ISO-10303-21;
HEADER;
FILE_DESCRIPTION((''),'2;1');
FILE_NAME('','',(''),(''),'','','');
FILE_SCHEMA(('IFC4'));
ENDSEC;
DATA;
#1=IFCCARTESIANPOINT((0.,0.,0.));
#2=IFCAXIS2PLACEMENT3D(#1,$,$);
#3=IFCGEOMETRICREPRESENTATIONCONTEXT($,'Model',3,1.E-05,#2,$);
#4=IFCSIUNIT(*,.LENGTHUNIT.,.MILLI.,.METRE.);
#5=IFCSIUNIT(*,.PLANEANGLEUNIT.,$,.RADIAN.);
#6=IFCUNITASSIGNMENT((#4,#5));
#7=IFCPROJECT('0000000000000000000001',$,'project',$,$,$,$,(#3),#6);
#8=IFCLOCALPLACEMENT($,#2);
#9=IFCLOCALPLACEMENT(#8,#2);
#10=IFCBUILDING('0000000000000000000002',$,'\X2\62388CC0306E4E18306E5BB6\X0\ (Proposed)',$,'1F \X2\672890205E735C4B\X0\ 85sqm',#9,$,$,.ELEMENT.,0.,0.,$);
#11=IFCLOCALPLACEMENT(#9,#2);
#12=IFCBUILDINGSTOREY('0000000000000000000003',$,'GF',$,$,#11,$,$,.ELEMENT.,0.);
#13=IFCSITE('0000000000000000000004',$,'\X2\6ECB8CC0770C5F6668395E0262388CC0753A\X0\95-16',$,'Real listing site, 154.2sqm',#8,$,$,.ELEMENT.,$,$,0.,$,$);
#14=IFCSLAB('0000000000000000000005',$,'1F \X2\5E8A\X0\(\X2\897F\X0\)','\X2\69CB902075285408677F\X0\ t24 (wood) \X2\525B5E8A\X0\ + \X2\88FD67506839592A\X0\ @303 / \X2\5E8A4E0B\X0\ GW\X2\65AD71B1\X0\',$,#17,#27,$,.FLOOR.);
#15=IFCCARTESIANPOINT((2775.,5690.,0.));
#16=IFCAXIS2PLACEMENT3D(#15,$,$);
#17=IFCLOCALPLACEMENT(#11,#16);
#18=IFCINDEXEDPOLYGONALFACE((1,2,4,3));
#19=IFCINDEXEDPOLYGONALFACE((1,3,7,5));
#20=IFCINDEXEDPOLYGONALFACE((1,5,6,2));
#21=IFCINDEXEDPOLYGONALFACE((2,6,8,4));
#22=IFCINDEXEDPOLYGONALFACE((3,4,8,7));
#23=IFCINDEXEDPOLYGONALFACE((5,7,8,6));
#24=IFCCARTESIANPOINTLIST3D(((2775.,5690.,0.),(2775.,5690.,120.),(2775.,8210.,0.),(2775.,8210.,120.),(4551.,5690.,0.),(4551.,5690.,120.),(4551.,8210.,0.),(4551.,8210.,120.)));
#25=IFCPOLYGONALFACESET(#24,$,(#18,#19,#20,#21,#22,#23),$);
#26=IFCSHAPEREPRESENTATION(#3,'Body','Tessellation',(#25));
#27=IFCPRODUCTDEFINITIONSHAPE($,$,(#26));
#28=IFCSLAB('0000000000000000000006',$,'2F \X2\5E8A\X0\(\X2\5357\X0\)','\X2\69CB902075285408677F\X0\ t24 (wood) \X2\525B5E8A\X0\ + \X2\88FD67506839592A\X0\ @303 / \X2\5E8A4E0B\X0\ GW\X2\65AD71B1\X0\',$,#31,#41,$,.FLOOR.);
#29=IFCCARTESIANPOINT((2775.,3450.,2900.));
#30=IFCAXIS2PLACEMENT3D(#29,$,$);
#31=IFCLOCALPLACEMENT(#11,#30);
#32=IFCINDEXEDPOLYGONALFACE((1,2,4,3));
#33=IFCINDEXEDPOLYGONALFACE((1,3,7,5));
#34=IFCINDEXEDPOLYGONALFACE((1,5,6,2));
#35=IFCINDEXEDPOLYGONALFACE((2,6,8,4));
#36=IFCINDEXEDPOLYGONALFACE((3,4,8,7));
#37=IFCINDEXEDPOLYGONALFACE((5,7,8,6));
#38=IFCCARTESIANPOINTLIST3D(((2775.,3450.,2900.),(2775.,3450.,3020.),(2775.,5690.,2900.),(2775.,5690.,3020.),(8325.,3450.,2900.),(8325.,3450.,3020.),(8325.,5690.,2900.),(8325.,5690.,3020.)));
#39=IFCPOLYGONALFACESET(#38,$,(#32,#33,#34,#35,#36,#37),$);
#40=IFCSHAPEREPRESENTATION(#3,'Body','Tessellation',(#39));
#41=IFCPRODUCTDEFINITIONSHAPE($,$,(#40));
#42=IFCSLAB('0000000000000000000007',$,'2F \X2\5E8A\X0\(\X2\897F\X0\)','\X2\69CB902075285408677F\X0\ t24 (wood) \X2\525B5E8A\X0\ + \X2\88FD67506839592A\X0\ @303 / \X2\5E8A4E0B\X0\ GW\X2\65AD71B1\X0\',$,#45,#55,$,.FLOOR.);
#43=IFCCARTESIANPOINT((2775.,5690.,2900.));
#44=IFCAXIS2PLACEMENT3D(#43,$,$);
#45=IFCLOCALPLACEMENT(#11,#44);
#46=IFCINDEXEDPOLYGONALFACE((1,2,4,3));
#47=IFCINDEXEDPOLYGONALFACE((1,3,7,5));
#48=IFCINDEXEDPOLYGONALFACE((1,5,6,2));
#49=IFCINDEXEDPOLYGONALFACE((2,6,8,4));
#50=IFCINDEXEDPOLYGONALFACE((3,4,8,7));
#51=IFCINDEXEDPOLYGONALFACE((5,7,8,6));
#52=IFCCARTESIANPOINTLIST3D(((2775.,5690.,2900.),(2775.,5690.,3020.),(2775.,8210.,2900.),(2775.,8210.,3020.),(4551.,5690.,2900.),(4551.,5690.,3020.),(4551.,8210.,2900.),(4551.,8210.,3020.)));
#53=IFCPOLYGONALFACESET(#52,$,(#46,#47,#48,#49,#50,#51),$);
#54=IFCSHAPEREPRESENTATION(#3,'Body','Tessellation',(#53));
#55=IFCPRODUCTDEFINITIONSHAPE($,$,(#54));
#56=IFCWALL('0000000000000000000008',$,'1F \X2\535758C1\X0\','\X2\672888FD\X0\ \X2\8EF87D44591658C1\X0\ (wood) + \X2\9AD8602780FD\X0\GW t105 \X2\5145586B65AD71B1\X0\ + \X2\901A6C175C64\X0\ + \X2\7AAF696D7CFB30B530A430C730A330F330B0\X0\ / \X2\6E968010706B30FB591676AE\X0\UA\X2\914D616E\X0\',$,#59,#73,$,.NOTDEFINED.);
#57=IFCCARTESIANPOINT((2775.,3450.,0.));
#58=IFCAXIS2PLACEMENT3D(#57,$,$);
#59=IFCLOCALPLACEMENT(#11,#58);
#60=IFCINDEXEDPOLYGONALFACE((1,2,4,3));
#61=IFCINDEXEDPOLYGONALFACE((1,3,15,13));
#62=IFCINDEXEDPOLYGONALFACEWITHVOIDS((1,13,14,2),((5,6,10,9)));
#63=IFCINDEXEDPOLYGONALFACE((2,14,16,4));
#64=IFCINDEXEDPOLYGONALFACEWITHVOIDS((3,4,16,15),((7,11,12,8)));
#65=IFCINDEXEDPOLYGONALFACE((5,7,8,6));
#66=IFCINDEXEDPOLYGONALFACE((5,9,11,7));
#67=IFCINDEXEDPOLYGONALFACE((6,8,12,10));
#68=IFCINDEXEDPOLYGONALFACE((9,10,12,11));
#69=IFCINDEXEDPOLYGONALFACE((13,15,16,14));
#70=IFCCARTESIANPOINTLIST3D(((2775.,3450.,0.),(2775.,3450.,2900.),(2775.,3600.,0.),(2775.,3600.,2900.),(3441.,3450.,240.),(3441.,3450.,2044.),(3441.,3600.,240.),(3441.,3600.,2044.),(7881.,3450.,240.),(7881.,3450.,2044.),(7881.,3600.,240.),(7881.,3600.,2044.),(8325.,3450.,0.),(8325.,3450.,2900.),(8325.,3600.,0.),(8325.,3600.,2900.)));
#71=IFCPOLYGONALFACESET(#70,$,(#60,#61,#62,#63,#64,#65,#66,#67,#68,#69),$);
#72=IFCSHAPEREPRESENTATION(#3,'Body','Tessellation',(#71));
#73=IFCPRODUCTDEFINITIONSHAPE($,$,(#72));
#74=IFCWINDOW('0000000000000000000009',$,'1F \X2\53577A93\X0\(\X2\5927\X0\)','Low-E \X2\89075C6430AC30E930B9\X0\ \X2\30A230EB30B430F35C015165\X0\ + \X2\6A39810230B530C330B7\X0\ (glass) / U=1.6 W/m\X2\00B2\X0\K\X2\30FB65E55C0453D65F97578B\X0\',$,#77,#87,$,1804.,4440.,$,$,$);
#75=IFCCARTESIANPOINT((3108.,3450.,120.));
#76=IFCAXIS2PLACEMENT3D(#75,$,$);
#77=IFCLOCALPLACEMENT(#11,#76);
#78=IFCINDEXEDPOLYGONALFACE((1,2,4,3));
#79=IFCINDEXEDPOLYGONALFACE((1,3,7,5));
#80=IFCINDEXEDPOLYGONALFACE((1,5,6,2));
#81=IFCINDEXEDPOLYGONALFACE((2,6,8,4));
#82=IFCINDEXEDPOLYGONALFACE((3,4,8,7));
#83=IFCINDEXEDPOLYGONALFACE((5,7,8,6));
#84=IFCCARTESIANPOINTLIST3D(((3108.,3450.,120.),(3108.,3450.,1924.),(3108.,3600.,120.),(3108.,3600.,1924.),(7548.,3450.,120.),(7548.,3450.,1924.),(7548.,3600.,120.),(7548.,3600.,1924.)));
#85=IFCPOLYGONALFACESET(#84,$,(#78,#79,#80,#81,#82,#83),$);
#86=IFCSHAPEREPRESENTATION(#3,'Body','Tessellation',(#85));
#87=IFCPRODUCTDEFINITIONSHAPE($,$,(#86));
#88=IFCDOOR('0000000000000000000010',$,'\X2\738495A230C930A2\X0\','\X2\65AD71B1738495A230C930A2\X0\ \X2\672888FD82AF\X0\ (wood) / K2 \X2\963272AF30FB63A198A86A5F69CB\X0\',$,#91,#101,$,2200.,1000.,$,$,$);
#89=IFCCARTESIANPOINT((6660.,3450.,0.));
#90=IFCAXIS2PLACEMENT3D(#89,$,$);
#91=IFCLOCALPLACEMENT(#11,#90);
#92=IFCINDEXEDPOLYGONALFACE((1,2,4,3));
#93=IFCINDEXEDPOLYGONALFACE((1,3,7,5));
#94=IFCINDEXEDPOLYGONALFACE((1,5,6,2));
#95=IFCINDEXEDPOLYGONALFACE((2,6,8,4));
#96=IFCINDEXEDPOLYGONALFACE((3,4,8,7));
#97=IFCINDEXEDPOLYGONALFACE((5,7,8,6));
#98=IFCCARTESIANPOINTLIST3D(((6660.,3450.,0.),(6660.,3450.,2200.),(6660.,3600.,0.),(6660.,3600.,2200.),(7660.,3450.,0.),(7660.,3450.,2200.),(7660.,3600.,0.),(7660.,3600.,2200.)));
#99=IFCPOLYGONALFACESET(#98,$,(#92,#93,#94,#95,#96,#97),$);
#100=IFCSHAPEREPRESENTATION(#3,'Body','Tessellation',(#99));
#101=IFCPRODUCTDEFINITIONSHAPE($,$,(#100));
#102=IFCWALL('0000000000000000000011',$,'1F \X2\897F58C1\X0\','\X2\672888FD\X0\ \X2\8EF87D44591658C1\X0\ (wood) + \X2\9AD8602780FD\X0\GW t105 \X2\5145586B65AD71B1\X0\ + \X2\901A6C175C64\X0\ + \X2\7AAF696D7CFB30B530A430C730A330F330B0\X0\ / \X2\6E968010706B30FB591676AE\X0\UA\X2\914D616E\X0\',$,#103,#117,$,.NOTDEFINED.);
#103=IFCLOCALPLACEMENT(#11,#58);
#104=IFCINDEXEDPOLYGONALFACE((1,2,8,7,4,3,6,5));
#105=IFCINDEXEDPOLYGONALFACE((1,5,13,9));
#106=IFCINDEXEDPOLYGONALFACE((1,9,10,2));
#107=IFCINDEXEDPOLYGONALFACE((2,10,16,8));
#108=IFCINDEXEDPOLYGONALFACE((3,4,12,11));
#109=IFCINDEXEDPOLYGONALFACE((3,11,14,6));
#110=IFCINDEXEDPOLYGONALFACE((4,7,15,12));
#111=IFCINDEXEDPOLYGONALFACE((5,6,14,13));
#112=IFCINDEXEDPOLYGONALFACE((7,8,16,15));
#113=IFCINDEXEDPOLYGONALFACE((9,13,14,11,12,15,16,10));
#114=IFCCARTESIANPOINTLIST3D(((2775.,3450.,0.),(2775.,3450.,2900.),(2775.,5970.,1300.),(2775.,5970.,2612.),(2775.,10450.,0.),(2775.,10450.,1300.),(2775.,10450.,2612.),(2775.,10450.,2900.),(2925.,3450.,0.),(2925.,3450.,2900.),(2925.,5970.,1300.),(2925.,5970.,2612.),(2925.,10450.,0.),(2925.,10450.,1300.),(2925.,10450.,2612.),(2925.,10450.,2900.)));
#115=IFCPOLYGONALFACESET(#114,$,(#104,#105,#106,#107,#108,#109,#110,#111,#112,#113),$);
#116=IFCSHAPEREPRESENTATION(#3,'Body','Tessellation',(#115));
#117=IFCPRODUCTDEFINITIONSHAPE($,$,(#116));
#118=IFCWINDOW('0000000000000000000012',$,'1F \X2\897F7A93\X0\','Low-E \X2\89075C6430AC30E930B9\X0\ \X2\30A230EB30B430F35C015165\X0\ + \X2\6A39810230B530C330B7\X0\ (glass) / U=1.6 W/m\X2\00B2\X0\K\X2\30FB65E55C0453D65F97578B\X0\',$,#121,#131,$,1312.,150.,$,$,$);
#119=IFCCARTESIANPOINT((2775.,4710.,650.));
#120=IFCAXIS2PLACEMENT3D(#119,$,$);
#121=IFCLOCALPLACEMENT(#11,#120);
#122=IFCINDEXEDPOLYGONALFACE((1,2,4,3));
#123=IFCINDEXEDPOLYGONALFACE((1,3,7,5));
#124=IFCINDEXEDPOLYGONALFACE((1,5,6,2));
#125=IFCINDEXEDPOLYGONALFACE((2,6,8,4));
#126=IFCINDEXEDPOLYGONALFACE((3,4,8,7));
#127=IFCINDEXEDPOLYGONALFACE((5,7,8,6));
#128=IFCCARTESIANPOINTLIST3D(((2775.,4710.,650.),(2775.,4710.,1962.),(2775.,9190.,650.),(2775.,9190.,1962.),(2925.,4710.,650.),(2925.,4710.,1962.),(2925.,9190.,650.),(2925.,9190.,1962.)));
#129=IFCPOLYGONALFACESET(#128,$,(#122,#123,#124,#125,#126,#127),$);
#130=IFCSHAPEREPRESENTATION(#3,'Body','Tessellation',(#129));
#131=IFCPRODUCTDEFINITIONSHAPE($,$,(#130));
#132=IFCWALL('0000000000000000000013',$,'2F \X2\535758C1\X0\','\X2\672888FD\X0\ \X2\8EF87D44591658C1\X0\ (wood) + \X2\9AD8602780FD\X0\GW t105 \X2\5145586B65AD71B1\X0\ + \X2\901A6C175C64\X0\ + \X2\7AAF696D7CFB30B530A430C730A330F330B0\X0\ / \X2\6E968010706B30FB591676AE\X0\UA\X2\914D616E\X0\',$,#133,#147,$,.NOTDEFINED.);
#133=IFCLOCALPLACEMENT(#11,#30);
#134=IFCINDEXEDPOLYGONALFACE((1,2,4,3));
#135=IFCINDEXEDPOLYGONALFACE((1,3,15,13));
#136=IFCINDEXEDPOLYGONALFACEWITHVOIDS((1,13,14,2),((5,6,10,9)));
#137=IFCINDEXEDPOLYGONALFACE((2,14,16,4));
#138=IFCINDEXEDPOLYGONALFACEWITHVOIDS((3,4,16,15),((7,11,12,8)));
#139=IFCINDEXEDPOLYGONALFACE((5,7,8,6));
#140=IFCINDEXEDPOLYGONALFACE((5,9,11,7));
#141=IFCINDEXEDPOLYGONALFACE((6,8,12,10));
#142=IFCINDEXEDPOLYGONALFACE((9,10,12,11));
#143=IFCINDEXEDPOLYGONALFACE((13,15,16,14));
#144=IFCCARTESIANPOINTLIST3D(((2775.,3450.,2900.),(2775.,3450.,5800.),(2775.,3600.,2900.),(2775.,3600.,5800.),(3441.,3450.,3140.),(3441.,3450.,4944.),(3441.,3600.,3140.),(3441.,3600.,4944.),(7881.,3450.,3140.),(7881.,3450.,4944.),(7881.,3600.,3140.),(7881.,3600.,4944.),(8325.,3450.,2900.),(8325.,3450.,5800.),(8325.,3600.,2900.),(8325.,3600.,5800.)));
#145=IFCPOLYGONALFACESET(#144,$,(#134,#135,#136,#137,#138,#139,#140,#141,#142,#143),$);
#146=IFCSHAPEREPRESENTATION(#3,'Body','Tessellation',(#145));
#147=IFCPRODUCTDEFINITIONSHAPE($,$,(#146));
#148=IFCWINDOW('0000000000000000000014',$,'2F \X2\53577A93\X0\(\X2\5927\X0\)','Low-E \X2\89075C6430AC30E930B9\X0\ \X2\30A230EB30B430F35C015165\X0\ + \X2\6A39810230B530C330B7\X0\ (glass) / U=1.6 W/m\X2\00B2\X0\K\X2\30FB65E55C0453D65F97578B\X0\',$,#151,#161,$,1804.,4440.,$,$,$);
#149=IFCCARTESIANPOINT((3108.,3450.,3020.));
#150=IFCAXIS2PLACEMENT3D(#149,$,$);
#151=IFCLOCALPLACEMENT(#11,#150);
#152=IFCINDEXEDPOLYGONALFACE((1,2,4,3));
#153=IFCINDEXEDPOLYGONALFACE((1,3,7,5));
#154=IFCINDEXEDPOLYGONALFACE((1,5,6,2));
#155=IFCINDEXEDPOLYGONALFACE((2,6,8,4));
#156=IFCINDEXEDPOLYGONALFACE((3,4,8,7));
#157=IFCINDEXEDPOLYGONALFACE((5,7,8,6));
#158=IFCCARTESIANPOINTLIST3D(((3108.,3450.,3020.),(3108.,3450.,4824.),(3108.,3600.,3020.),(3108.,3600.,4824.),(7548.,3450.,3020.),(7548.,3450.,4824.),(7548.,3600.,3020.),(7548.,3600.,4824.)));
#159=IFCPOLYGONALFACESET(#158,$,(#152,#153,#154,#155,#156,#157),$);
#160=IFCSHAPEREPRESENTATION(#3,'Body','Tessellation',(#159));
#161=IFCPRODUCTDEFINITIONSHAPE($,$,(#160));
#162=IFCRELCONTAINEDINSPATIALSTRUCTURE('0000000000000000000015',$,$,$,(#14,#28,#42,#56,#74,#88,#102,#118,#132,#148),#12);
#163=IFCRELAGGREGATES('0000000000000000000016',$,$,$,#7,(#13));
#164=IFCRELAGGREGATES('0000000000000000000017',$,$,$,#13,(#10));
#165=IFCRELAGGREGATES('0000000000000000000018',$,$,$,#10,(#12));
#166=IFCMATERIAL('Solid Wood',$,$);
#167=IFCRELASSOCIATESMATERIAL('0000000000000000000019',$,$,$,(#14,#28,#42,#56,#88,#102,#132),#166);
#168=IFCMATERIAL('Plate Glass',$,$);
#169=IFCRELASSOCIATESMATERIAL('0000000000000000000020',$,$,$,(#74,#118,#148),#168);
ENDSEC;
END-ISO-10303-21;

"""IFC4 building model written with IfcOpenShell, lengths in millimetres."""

from ifc_helpers import new_model, si_unit, frame, frame_2d, origin, place, context, project, spatial, rectangle, extrude, material, element, fill, save


model = new_model("IFC4")

# Units and contexts
model_context = context("Model", 3, precision=1e-05, world=origin())
ifc_project = project(units=[si_unit("LENGTHUNIT", "METRE", prefix="MILLI"), si_unit("PLANEANGLEUNIT", "RADIAN")], contexts=[model_context])

# Site, building, storey
site_placement = place(None, origin())
site = spatial("IfcSite", under=ifc_project, at=site_placement, Name="滋賀県彦根市戸賀町95-16", ObjectType="Real listing site, 154.2sqm", CompositionType="ELEMENT", RefElevation=0.0)
building_placement = place(site_placement, origin())
building = spatial("IfcBuilding", under=site, at=building_placement, Name="戸賀の丘の家 (Proposed)", ObjectType="1F 木造平屋 85sqm", CompositionType="ELEMENT", ElevationOfRefHeight=0.0, ElevationOfTerrain=0.0)
storey_placement = place(building_placement, origin())
storey = spatial("IfcBuildingStorey", under=building, at=storey_placement, Name="GF", CompositionType="ELEMENT", Elevation=0.0)

# Slabs
ifc_material_1 = material(Name="Solid Wood")
slab_1_placement = place(storey_placement, frame((2775.0, 5690.0, 0.0)))
element("IfcSlab", 1, at=slab_1_placement, inside=storey, material=ifc_material_1, Name="1F 床(西)", Description="構造用合板 t24 (wood) 剛床 + 製材根太 @303 / 床下 GW断熱", PredefinedType="FLOOR", context=model_context, shape_type="SweptSolid", body=[
    extrude(rectangle(XDim=1776.0, YDim=2520.0, at=frame_2d((888.0, 1260.0))), frame((2775.0, 5690.0, 0.0)), (0.0, 0.0, 1.0), 120.0),
])
slab_2_placement = place(storey_placement, frame((2775.0, 3450.0, 2900.0)))
element("IfcSlab", 2, at=slab_2_placement, inside=storey, material=ifc_material_1, Name="2F 床(南)", Description="構造用合板 t24 (wood) 剛床 + 製材根太 @303 / 床下 GW断熱", PredefinedType="FLOOR", context=model_context, shape_type="SweptSolid", body=[
    extrude(rectangle(XDim=5550.0, YDim=2240.0, at=frame_2d((2775.0, 1120.0))), frame((2775.0, 3450.0, 2900.0)), (0.0, 0.0, 1.0), 120.0),
])
slab_3_placement = place(storey_placement, frame((2775.0, 5690.0, 2900.0)))
element("IfcSlab", 3, at=slab_3_placement, inside=storey, material=ifc_material_1, Name="2F 床(西)", Description="構造用合板 t24 (wood) 剛床 + 製材根太 @303 / 床下 GW断熱", PredefinedType="FLOOR", context=model_context, shape_type="SweptSolid", body=[
    extrude(rectangle(XDim=1776.0, YDim=2520.0, at=frame_2d((888.0, 1260.0))), frame((2775.0, 5690.0, 2900.0)), (0.0, 0.0, 1.0), 120.0),
])

# Wall, openings, window, door
wall_1_placement = place(storey_placement, frame((2775.0, 3450.0, 0.0)))
wall_1 = element("IfcWall", 4, at=wall_1_placement, inside=storey, material=ifc_material_1, Name="1F 南壁", Description="木製 軸組外壁 (wood) + 高性能GW t105 充填断熱 + 通気層 + 窯業系サイディング / 準耐火・外皮UA配慮", PredefinedType="NOTDEFINED", context=model_context, shape_type="SweptSolid", body=[
    extrude(rectangle(XDim=5550.0, YDim=150.0, at=frame_2d((2775.0, 75.0))), frame((2775.0, 3450.0, 0.0)), (0.0, 0.0, 1.0), 2900.0),
])
opening_1_placement = place(storey_placement, frame((3108.0, 3450.0, 120.0)))
opening_1 = element("IfcOpeningElement", 5, at=opening_1_placement, cuts=wall_1, PredefinedType="NOTDEFINED", context=model_context, shape_type="SweptSolid", body=[
    extrude(rectangle(XDim=4440.0, YDim=150.0, at=frame_2d((2220.0, 75.0))), frame((3108.0, 3450.0, 120.0)), (0.0, 0.0, 1.0), 1804.0),
])
opening_2_placement = place(storey_placement, frame((6660.0, 3450.0, 0.0)))
opening_2 = element("IfcOpeningElement", 6, at=opening_2_placement, cuts=wall_1, PredefinedType="NOTDEFINED", context=model_context, shape_type="SweptSolid", body=[
    extrude(rectangle(XDim=1000.0, YDim=150.0, at=frame_2d((500.0, 75.0))), frame((6660.0, 3450.0, 0.0)), (0.0, 0.0, 1.0), 2200.0),
])
ifc_material_2 = material(Name="Plate Glass")
window_1_placement = place(storey_placement, frame((3108.0, 3450.0, 120.0)))
window_1 = element("IfcWindow", 7, at=window_1_placement, inside=storey, material=ifc_material_2, Name="1F 南窓(大)", Description="Low-E 複層ガラス アルゴン封入 + 樹脂サッシ (glass) / U=1.6 W/m²K・日射取得型", OverallHeight=1804.0, OverallWidth=4440.0, context=model_context, shape_type="SweptSolid", body=[
    extrude(rectangle(XDim=4440.0, YDim=150.0, at=frame_2d((2220.0, 75.0))), frame((3108.0, 3450.0, 120.0)), (0.0, 0.0, 1.0), 1804.0),
])
fill(opening_1, window_1)
door_placement = place(storey_placement, frame((6660.0, 3450.0, 0.0)))
door = element("IfcDoor", 8, at=door_placement, inside=storey, material=ifc_material_1, Name="玄関ドア", Description="断熱玄関ドア 木製芯 (wood) / K2 防犯・採風機構", OverallHeight=2200.0, OverallWidth=1000.0, context=model_context, shape_type="SweptSolid", body=[
    extrude(rectangle(XDim=1000.0, YDim=150.0, at=frame_2d((500.0, 75.0))), frame((6660.0, 3450.0, 0.0)), (0.0, 0.0, 1.0), 2200.0),
])
fill(opening_2, door)

# Walls, openings, windows
wall_2_placement = place(storey_placement, frame((2775.0, 3450.0, 0.0)))
wall_2 = element("IfcWall", 9, at=wall_2_placement, inside=storey, material=ifc_material_1, Name="1F 西壁", Description="木製 軸組外壁 (wood) + 高性能GW t105 充填断熱 + 通気層 + 窯業系サイディング / 準耐火・外皮UA配慮", PredefinedType="NOTDEFINED", context=model_context, shape_type="SweptSolid", body=[
    extrude(rectangle(XDim=150.0, YDim=7000.0, at=frame_2d((75.0, 3500.0))), frame((2775.0, 3450.0, 0.0)), (0.0, 0.0, 1.0), 2900.0),
])
opening_3_placement = place(storey_placement, frame((2775.0, 4710.0, 650.0)))
opening_3 = element("IfcOpeningElement", 10, at=opening_3_placement, cuts=wall_2, PredefinedType="NOTDEFINED", context=model_context, shape_type="SweptSolid", body=[
    extrude(rectangle(XDim=150.0, YDim=4480.0, at=frame_2d((75.0, 2240.0))), frame((2775.0, 4710.0, 650.0)), (0.0, 0.0, 1.0), 1312.0),
])
window_2_placement = place(storey_placement, frame((2775.0, 4710.0, 650.0)))
window_2 = element("IfcWindow", 11, at=window_2_placement, inside=storey, material=ifc_material_2, Name="1F 西窓", Description="Low-E 複層ガラス アルゴン封入 + 樹脂サッシ (glass) / U=1.6 W/m²K・日射取得型", OverallHeight=1312.0, OverallWidth=150.0, context=model_context, shape_type="SweptSolid", body=[
    extrude(rectangle(XDim=150.0, YDim=4480.0, at=frame_2d((75.0, 2240.0))), frame((2775.0, 4710.0, 650.0)), (0.0, 0.0, 1.0), 1312.0),
])
fill(opening_3, window_2)
wall_3_placement = place(storey_placement, frame((2775.0, 3450.0, 2900.0)))
wall_3 = element("IfcWall", 12, at=wall_3_placement, inside=storey, material=ifc_material_1, Name="2F 南壁", Description="木製 軸組外壁 (wood) + 高性能GW t105 充填断熱 + 通気層 + 窯業系サイディング / 準耐火・外皮UA配慮", PredefinedType="NOTDEFINED", context=model_context, shape_type="SweptSolid", body=[
    extrude(rectangle(XDim=5550.0, YDim=150.0, at=frame_2d((2775.0, 75.0))), frame((2775.0, 3450.0, 2900.0)), (0.0, 0.0, 1.0), 2900.0),
])
opening_4_placement = place(storey_placement, frame((3108.0, 3450.0, 3020.0)))
opening_4 = element("IfcOpeningElement", 13, at=opening_4_placement, cuts=wall_3, PredefinedType="NOTDEFINED", context=model_context, shape_type="SweptSolid", body=[
    extrude(rectangle(XDim=4440.0, YDim=150.0, at=frame_2d((2220.0, 75.0))), frame((3108.0, 3450.0, 3020.0)), (0.0, 0.0, 1.0), 1804.0),
])
window_3_placement = place(storey_placement, frame((3108.0, 3450.0, 3020.0)))
window_3 = element("IfcWindow", 14, at=window_3_placement, inside=storey, material=ifc_material_2, Name="2F 南窓(大)", Description="Low-E 複層ガラス アルゴン封入 + 樹脂サッシ (glass) / U=1.6 W/m²K・日射取得型", OverallHeight=1804.0, OverallWidth=4440.0, context=model_context, shape_type="SweptSolid", body=[
    extrude(rectangle(XDim=4440.0, YDim=150.0, at=frame_2d((2220.0, 75.0))), frame((3108.0, 3450.0, 3020.0)), (0.0, 0.0, 1.0), 1804.0),
])
fill(opening_4, window_3)

save(model, "model.ifc")
